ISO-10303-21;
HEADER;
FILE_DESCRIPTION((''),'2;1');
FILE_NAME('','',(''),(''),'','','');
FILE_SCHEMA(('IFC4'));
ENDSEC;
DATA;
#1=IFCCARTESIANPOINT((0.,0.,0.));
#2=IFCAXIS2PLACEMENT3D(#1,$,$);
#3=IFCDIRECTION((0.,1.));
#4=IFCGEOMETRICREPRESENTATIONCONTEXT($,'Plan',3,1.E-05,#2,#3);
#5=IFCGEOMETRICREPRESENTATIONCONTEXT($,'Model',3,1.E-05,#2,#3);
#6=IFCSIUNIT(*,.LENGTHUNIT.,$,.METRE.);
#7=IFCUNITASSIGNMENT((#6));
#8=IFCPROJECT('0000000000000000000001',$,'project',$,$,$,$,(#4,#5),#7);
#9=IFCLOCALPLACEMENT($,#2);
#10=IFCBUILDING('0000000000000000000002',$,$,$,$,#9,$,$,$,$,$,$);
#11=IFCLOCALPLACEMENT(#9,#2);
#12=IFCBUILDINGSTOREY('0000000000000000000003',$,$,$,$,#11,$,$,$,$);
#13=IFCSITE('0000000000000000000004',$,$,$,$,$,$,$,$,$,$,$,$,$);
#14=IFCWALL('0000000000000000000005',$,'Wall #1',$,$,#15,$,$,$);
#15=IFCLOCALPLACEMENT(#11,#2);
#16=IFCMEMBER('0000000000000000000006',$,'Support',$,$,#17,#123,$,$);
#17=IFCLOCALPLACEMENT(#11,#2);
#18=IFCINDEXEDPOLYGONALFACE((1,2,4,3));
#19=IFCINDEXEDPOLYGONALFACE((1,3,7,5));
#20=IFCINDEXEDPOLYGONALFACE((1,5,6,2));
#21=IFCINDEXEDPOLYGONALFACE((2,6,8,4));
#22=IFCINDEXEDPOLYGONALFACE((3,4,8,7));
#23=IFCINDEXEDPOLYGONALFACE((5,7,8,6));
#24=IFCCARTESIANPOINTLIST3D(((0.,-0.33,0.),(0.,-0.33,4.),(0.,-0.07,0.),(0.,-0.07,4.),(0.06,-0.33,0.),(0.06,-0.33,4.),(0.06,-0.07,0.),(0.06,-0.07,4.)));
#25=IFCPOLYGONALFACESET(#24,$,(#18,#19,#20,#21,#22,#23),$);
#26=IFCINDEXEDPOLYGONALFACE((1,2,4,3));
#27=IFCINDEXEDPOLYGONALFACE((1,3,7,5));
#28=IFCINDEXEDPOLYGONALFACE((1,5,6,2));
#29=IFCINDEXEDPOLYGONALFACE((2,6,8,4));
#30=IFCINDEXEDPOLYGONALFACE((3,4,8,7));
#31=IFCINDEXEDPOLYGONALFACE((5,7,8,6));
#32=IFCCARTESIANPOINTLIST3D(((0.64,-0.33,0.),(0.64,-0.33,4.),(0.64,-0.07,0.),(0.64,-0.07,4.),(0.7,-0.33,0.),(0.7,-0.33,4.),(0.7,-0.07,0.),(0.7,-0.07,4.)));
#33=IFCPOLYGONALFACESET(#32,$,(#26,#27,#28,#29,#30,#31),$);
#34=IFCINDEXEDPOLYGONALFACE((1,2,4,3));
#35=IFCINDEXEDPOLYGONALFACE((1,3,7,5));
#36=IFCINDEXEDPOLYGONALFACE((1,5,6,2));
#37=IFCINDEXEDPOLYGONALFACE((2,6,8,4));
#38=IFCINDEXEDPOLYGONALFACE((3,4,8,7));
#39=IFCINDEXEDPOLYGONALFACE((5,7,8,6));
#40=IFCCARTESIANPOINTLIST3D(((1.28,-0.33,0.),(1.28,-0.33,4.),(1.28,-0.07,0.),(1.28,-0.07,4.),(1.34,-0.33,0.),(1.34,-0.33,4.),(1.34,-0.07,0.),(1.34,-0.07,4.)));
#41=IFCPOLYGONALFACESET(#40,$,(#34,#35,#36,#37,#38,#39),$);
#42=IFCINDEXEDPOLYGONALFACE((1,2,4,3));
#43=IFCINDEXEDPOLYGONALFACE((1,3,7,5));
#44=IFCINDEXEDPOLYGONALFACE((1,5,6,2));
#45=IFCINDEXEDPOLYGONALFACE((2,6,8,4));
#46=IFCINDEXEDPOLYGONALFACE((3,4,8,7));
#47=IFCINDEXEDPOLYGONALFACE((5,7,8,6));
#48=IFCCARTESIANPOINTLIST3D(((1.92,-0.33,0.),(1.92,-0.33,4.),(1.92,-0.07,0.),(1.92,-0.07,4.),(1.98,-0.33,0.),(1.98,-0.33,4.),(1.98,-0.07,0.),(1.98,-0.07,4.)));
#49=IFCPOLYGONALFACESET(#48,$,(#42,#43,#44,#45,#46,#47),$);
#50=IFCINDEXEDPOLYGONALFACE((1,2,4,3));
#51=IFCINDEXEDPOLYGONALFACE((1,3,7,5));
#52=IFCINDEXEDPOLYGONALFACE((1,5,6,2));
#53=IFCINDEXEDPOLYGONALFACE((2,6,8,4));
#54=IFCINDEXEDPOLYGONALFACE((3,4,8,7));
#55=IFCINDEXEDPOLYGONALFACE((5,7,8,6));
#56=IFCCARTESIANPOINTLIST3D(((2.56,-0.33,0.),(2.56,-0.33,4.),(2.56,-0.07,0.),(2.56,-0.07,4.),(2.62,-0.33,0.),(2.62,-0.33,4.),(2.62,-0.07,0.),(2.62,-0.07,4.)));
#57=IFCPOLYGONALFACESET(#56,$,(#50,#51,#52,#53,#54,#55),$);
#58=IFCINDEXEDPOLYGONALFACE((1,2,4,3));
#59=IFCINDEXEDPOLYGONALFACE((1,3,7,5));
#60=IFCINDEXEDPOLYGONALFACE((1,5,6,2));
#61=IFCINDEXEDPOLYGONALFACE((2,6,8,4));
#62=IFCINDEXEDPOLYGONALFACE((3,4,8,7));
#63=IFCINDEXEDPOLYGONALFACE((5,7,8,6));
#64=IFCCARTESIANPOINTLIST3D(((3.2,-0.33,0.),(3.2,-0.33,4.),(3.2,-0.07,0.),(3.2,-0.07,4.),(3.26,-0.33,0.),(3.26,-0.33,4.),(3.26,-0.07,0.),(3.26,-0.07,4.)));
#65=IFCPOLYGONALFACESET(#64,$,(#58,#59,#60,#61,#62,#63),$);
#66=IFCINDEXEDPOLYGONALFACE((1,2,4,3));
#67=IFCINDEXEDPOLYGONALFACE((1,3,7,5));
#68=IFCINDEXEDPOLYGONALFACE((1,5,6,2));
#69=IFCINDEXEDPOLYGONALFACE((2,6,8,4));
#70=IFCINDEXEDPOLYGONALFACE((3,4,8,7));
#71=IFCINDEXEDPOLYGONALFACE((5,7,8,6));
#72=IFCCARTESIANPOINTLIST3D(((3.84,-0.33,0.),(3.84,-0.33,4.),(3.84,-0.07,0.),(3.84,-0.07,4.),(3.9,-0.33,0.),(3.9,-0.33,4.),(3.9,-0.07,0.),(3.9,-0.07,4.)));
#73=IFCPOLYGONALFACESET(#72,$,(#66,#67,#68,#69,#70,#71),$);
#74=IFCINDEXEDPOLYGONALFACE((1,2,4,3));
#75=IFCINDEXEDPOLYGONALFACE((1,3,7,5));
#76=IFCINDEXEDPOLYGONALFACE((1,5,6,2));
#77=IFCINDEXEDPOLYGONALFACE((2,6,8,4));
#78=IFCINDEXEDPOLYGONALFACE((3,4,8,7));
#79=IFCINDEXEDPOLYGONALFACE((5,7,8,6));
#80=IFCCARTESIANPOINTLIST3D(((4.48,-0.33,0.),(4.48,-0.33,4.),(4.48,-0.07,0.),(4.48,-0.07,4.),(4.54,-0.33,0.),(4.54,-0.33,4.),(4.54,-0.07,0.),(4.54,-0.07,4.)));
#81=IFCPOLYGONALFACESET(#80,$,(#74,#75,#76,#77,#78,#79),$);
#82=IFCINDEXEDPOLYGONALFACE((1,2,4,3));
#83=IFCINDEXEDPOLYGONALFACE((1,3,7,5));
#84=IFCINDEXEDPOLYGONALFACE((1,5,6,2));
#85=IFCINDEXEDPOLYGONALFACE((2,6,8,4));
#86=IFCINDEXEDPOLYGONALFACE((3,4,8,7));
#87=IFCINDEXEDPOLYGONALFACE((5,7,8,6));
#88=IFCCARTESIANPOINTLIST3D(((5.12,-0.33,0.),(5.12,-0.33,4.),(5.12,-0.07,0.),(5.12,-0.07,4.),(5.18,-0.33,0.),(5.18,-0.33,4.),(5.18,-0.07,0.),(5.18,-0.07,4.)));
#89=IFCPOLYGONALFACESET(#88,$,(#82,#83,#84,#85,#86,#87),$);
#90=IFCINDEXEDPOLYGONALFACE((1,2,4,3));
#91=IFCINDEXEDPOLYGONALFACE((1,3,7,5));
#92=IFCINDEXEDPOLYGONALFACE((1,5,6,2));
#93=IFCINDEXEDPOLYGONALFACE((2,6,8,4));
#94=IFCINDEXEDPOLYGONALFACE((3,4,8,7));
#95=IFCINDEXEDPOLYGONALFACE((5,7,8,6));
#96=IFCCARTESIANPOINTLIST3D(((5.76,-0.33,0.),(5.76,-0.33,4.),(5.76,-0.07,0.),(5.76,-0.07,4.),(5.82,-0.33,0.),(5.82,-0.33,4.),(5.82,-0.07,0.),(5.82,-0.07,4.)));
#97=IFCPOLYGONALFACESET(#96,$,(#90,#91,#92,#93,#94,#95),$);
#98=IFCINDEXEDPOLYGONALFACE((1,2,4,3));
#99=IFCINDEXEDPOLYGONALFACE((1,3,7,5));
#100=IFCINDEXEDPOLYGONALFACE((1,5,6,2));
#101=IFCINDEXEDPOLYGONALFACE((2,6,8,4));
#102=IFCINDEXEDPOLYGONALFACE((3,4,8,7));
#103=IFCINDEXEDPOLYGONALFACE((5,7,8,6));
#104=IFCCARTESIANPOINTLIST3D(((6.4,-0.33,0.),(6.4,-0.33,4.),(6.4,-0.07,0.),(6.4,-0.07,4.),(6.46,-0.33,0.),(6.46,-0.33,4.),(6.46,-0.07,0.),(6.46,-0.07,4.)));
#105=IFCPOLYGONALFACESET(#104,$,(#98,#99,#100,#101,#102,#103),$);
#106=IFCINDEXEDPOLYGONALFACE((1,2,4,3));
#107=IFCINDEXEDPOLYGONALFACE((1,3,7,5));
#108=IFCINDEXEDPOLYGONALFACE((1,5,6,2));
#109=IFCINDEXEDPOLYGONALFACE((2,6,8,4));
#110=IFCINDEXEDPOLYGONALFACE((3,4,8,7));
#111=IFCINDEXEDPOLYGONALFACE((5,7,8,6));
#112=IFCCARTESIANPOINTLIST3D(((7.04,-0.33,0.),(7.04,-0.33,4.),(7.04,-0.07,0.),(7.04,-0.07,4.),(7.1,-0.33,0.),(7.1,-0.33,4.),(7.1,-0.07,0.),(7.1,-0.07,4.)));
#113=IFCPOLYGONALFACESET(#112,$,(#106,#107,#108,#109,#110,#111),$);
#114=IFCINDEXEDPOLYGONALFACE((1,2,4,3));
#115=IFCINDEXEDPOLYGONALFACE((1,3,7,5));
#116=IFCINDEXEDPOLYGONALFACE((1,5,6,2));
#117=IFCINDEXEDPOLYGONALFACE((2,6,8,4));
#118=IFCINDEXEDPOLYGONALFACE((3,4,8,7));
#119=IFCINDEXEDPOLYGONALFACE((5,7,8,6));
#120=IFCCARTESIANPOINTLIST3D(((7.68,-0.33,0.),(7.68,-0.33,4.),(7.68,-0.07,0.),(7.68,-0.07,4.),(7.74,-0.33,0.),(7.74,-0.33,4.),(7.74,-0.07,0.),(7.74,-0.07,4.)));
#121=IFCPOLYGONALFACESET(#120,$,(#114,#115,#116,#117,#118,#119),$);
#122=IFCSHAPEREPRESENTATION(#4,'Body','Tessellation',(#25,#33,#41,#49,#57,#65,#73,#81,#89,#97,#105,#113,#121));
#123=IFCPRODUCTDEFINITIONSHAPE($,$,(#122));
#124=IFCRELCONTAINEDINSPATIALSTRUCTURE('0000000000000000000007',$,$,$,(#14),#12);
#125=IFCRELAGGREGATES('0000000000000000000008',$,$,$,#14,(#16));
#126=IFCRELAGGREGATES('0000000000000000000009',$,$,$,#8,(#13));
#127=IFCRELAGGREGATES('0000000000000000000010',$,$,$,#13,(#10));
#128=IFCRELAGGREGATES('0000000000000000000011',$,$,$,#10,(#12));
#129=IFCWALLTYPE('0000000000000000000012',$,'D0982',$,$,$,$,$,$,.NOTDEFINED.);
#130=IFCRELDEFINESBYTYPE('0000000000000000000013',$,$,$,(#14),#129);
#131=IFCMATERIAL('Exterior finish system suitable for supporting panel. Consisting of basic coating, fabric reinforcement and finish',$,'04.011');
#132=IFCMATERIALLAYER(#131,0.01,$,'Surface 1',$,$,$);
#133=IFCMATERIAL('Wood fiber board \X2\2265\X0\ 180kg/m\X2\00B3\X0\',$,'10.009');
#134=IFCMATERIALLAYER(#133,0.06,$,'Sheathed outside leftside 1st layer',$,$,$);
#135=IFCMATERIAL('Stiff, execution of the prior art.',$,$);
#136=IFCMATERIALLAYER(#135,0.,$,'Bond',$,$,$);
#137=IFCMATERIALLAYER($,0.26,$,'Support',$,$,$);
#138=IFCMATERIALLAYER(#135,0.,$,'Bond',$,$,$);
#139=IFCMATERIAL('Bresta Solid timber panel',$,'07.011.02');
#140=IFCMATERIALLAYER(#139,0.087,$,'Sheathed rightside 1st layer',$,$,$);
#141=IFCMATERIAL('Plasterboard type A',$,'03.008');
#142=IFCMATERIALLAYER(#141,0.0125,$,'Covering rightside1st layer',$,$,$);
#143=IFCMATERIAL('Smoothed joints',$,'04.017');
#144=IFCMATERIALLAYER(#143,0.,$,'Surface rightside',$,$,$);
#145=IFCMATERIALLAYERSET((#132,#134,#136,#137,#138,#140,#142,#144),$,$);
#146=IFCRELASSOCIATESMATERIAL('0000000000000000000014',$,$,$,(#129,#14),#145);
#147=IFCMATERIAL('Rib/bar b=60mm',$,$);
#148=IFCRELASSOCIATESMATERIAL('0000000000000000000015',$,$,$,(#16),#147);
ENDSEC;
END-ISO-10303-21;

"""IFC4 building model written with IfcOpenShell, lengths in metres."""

from ifc_helpers import new_model, si_unit, direction, frame, frame_2d, origin, place, context, project, spatial, rectangle, extrude, material, layer, layer_set, type_object, element, aggregate, save


model = new_model("IFC4")

# Units and contexts
plan_context = context("Plan", 3, precision=1e-05, world=origin(), true_north=direction((0.0, 1.0)))
model_context = context("Model", 3, precision=1e-05, world=origin(), true_north=direction((0.0, 1.0)))
ifc_project = project(units=[si_unit("LENGTHUNIT", "METRE")], contexts=[plan_context, model_context])

# Site, building, storey
site = spatial("IfcSite", under=ifc_project)
building_placement = place(None, origin())
building = spatial("IfcBuilding", under=site, at=building_placement)
storey_placement = place(building_placement, origin())
storey = spatial("IfcBuildingStorey", under=building, at=storey_placement)

# Wall, member
ifc_material_1 = material(Name="Exterior finish system suitable for supporting panel. Consisting of basic coating, fabric reinforcement and finish", Category="04.011")
ifc_layer_1 = layer(ifc_material_1, 0.01, Name="Surface 1")
ifc_material_2 = material(Name="Wood fiber board ≥ 180kg/m³", Category="10.009")
ifc_layer_2 = layer(ifc_material_2, 0.06, Name="Sheathed outside leftside 1st layer")
ifc_material_3 = material(Name="Stiff, execution of the prior art.")
ifc_layer_3 = layer(ifc_material_3, 0.0, Name="Bond")
ifc_layer_4 = layer(None, 0.26, Name="Support")
ifc_layer_5 = layer(ifc_material_3, 0.0, Name="Bond")
ifc_material_4 = material(Name="Bresta Solid timber panel", Category="07.011.02")
ifc_layer_6 = layer(ifc_material_4, 0.087, Name="Sheathed rightside 1st layer")
ifc_material_5 = material(Name="Plasterboard type A", Category="03.008")
ifc_layer_7 = layer(ifc_material_5, 0.0125, Name="Covering rightside1st layer")
ifc_material_6 = material(Name="Smoothed joints", Category="04.017")
ifc_layer_8 = layer(ifc_material_6, 0.0, Name="Surface rightside")
ifc_layer_set = layer_set([ifc_layer_1, ifc_layer_2, ifc_layer_3, ifc_layer_4, ifc_layer_5, ifc_layer_6, ifc_layer_7, ifc_layer_8])
wall_type = type_object("IfcWallType", Name="D0982", PredefinedType="NOTDEFINED", material=ifc_layer_set)
wall_placement = place(None, frame((0.0, 0.0, 0.0), z_axis=(0.0, -1.0, 0.0), x_axis=(1.0, 0.0, 0.0)))
wall = element("IfcWall", 1, at=wall_placement, inside=storey, type_object=wall_type, material=ifc_layer_set, Name="Wall #1")
ifc_material_7 = material(Name="Rib/bar b=60mm")
member_1_placement = place(wall_placement, origin())
member_1 = element("IfcMember", 2, at=member_1_placement, material=ifc_material_7, Name="Support", context=plan_context, shape_type="SweptSolid", body=[
    extrude(rectangle(XDim=0.06, YDim=0.26, at=frame_2d((0.03, 0.13), x_axis=(1.0, 0.0))), frame((0.0, 4.0, 0.07), z_axis=(0.0, -1.0, 0.0), x_axis=(1.0, 0.0, 0.0)), (0.0, 0.0, 1.0), 4.0),
    extrude(rectangle(XDim=0.06, YDim=0.26, at=frame_2d((0.03, 0.13), x_axis=(1.0, 0.0))), frame((0.64, 4.0, 0.07), z_axis=(0.0, -1.0, 0.0), x_axis=(1.0, 0.0, 0.0)), (0.0, 0.0, 1.0), 4.0),
    extrude(rectangle(XDim=0.06, YDim=0.26, at=frame_2d((0.03, 0.13), x_axis=(1.0, 0.0))), frame((1.28, 4.0, 0.07), z_axis=(0.0, -1.0, 0.0), x_axis=(1.0, 0.0, 0.0)), (0.0, 0.0, 1.0), 4.0),
    extrude(rectangle(XDim=0.06, YDim=0.26, at=frame_2d((0.03, 0.13), x_axis=(1.0, 0.0))), frame((1.92, 4.0, 0.07), z_axis=(0.0, -1.0, 0.0), x_axis=(1.0, 0.0, 0.0)), (0.0, 0.0, 1.0), 4.0),
    extrude(rectangle(XDim=0.06, YDim=0.26, at=frame_2d((0.03, 0.13), x_axis=(1.0, 0.0))), frame((2.56, 4.0, 0.07), z_axis=(0.0, -1.0, 0.0), x_axis=(1.0, 0.0, 0.0)), (0.0, 0.0, 1.0), 4.0),
    extrude(rectangle(XDim=0.06, YDim=0.26, at=frame_2d((0.03, 0.13), x_axis=(1.0, 0.0))), frame((3.2, 4.0, 0.07), z_axis=(0.0, -1.0, 0.0), x_axis=(1.0, 0.0, 0.0)), (0.0, 0.0, 1.0), 4.0),
    extrude(rectangle(XDim=0.06, YDim=0.26, at=frame_2d((0.03, 0.13), x_axis=(1.0, 0.0))), frame((3.84, 4.0, 0.07), z_axis=(0.0, -1.0, 0.0), x_axis=(1.0, 0.0, 0.0)), (0.0, 0.0, 1.0), 4.0),
    extrude(rectangle(XDim=0.06, YDim=0.26, at=frame_2d((0.03, 0.13), x_axis=(1.0, 0.0))), frame((4.48, 4.0, 0.07), z_axis=(0.0, -1.0, 0.0), x_axis=(1.0, 0.0, 0.0)), (0.0, 0.0, 1.0), 4.0),
    extrude(rectangle(XDim=0.06, YDim=0.26, at=frame_2d((0.03, 0.13), x_axis=(1.0, 0.0))), frame((5.12, 4.0, 0.07), z_axis=(0.0, -1.0, 0.0), x_axis=(1.0, 0.0, 0.0)), (0.0, 0.0, 1.0), 4.0),
    extrude(rectangle(XDim=0.06, YDim=0.26, at=frame_2d((0.03, 0.13), x_axis=(1.0, 0.0))), frame((5.76, 4.0, 0.07), z_axis=(0.0, -1.0, 0.0), x_axis=(1.0, 0.0, 0.0)), (0.0, 0.0, 1.0), 4.0),
    extrude(rectangle(XDim=0.06, YDim=0.26, at=frame_2d((0.03, 0.13), x_axis=(1.0, 0.0))), frame((6.4, 4.0, 0.07), z_axis=(0.0, -1.0, 0.0), x_axis=(1.0, 0.0, 0.0)), (0.0, 0.0, 1.0), 4.0),
    extrude(rectangle(XDim=0.06, YDim=0.26, at=frame_2d((0.03, 0.13), x_axis=(1.0, 0.0))), frame((7.04, 4.0, 0.07), z_axis=(0.0, -1.0, 0.0), x_axis=(1.0, 0.0, 0.0)), (0.0, 0.0, 1.0), 4.0),
    extrude(rectangle(XDim=0.06, YDim=0.26, at=frame_2d((0.03, 0.13), x_axis=(1.0, 0.0))), frame((7.68, 4.0, 0.07), z_axis=(0.0, -1.0, 0.0), x_axis=(1.0, 0.0, 0.0)), (0.0, 0.0, 1.0), 4.0),
])
aggregate(wall, [member_1])

save(model, "model.ifc")
